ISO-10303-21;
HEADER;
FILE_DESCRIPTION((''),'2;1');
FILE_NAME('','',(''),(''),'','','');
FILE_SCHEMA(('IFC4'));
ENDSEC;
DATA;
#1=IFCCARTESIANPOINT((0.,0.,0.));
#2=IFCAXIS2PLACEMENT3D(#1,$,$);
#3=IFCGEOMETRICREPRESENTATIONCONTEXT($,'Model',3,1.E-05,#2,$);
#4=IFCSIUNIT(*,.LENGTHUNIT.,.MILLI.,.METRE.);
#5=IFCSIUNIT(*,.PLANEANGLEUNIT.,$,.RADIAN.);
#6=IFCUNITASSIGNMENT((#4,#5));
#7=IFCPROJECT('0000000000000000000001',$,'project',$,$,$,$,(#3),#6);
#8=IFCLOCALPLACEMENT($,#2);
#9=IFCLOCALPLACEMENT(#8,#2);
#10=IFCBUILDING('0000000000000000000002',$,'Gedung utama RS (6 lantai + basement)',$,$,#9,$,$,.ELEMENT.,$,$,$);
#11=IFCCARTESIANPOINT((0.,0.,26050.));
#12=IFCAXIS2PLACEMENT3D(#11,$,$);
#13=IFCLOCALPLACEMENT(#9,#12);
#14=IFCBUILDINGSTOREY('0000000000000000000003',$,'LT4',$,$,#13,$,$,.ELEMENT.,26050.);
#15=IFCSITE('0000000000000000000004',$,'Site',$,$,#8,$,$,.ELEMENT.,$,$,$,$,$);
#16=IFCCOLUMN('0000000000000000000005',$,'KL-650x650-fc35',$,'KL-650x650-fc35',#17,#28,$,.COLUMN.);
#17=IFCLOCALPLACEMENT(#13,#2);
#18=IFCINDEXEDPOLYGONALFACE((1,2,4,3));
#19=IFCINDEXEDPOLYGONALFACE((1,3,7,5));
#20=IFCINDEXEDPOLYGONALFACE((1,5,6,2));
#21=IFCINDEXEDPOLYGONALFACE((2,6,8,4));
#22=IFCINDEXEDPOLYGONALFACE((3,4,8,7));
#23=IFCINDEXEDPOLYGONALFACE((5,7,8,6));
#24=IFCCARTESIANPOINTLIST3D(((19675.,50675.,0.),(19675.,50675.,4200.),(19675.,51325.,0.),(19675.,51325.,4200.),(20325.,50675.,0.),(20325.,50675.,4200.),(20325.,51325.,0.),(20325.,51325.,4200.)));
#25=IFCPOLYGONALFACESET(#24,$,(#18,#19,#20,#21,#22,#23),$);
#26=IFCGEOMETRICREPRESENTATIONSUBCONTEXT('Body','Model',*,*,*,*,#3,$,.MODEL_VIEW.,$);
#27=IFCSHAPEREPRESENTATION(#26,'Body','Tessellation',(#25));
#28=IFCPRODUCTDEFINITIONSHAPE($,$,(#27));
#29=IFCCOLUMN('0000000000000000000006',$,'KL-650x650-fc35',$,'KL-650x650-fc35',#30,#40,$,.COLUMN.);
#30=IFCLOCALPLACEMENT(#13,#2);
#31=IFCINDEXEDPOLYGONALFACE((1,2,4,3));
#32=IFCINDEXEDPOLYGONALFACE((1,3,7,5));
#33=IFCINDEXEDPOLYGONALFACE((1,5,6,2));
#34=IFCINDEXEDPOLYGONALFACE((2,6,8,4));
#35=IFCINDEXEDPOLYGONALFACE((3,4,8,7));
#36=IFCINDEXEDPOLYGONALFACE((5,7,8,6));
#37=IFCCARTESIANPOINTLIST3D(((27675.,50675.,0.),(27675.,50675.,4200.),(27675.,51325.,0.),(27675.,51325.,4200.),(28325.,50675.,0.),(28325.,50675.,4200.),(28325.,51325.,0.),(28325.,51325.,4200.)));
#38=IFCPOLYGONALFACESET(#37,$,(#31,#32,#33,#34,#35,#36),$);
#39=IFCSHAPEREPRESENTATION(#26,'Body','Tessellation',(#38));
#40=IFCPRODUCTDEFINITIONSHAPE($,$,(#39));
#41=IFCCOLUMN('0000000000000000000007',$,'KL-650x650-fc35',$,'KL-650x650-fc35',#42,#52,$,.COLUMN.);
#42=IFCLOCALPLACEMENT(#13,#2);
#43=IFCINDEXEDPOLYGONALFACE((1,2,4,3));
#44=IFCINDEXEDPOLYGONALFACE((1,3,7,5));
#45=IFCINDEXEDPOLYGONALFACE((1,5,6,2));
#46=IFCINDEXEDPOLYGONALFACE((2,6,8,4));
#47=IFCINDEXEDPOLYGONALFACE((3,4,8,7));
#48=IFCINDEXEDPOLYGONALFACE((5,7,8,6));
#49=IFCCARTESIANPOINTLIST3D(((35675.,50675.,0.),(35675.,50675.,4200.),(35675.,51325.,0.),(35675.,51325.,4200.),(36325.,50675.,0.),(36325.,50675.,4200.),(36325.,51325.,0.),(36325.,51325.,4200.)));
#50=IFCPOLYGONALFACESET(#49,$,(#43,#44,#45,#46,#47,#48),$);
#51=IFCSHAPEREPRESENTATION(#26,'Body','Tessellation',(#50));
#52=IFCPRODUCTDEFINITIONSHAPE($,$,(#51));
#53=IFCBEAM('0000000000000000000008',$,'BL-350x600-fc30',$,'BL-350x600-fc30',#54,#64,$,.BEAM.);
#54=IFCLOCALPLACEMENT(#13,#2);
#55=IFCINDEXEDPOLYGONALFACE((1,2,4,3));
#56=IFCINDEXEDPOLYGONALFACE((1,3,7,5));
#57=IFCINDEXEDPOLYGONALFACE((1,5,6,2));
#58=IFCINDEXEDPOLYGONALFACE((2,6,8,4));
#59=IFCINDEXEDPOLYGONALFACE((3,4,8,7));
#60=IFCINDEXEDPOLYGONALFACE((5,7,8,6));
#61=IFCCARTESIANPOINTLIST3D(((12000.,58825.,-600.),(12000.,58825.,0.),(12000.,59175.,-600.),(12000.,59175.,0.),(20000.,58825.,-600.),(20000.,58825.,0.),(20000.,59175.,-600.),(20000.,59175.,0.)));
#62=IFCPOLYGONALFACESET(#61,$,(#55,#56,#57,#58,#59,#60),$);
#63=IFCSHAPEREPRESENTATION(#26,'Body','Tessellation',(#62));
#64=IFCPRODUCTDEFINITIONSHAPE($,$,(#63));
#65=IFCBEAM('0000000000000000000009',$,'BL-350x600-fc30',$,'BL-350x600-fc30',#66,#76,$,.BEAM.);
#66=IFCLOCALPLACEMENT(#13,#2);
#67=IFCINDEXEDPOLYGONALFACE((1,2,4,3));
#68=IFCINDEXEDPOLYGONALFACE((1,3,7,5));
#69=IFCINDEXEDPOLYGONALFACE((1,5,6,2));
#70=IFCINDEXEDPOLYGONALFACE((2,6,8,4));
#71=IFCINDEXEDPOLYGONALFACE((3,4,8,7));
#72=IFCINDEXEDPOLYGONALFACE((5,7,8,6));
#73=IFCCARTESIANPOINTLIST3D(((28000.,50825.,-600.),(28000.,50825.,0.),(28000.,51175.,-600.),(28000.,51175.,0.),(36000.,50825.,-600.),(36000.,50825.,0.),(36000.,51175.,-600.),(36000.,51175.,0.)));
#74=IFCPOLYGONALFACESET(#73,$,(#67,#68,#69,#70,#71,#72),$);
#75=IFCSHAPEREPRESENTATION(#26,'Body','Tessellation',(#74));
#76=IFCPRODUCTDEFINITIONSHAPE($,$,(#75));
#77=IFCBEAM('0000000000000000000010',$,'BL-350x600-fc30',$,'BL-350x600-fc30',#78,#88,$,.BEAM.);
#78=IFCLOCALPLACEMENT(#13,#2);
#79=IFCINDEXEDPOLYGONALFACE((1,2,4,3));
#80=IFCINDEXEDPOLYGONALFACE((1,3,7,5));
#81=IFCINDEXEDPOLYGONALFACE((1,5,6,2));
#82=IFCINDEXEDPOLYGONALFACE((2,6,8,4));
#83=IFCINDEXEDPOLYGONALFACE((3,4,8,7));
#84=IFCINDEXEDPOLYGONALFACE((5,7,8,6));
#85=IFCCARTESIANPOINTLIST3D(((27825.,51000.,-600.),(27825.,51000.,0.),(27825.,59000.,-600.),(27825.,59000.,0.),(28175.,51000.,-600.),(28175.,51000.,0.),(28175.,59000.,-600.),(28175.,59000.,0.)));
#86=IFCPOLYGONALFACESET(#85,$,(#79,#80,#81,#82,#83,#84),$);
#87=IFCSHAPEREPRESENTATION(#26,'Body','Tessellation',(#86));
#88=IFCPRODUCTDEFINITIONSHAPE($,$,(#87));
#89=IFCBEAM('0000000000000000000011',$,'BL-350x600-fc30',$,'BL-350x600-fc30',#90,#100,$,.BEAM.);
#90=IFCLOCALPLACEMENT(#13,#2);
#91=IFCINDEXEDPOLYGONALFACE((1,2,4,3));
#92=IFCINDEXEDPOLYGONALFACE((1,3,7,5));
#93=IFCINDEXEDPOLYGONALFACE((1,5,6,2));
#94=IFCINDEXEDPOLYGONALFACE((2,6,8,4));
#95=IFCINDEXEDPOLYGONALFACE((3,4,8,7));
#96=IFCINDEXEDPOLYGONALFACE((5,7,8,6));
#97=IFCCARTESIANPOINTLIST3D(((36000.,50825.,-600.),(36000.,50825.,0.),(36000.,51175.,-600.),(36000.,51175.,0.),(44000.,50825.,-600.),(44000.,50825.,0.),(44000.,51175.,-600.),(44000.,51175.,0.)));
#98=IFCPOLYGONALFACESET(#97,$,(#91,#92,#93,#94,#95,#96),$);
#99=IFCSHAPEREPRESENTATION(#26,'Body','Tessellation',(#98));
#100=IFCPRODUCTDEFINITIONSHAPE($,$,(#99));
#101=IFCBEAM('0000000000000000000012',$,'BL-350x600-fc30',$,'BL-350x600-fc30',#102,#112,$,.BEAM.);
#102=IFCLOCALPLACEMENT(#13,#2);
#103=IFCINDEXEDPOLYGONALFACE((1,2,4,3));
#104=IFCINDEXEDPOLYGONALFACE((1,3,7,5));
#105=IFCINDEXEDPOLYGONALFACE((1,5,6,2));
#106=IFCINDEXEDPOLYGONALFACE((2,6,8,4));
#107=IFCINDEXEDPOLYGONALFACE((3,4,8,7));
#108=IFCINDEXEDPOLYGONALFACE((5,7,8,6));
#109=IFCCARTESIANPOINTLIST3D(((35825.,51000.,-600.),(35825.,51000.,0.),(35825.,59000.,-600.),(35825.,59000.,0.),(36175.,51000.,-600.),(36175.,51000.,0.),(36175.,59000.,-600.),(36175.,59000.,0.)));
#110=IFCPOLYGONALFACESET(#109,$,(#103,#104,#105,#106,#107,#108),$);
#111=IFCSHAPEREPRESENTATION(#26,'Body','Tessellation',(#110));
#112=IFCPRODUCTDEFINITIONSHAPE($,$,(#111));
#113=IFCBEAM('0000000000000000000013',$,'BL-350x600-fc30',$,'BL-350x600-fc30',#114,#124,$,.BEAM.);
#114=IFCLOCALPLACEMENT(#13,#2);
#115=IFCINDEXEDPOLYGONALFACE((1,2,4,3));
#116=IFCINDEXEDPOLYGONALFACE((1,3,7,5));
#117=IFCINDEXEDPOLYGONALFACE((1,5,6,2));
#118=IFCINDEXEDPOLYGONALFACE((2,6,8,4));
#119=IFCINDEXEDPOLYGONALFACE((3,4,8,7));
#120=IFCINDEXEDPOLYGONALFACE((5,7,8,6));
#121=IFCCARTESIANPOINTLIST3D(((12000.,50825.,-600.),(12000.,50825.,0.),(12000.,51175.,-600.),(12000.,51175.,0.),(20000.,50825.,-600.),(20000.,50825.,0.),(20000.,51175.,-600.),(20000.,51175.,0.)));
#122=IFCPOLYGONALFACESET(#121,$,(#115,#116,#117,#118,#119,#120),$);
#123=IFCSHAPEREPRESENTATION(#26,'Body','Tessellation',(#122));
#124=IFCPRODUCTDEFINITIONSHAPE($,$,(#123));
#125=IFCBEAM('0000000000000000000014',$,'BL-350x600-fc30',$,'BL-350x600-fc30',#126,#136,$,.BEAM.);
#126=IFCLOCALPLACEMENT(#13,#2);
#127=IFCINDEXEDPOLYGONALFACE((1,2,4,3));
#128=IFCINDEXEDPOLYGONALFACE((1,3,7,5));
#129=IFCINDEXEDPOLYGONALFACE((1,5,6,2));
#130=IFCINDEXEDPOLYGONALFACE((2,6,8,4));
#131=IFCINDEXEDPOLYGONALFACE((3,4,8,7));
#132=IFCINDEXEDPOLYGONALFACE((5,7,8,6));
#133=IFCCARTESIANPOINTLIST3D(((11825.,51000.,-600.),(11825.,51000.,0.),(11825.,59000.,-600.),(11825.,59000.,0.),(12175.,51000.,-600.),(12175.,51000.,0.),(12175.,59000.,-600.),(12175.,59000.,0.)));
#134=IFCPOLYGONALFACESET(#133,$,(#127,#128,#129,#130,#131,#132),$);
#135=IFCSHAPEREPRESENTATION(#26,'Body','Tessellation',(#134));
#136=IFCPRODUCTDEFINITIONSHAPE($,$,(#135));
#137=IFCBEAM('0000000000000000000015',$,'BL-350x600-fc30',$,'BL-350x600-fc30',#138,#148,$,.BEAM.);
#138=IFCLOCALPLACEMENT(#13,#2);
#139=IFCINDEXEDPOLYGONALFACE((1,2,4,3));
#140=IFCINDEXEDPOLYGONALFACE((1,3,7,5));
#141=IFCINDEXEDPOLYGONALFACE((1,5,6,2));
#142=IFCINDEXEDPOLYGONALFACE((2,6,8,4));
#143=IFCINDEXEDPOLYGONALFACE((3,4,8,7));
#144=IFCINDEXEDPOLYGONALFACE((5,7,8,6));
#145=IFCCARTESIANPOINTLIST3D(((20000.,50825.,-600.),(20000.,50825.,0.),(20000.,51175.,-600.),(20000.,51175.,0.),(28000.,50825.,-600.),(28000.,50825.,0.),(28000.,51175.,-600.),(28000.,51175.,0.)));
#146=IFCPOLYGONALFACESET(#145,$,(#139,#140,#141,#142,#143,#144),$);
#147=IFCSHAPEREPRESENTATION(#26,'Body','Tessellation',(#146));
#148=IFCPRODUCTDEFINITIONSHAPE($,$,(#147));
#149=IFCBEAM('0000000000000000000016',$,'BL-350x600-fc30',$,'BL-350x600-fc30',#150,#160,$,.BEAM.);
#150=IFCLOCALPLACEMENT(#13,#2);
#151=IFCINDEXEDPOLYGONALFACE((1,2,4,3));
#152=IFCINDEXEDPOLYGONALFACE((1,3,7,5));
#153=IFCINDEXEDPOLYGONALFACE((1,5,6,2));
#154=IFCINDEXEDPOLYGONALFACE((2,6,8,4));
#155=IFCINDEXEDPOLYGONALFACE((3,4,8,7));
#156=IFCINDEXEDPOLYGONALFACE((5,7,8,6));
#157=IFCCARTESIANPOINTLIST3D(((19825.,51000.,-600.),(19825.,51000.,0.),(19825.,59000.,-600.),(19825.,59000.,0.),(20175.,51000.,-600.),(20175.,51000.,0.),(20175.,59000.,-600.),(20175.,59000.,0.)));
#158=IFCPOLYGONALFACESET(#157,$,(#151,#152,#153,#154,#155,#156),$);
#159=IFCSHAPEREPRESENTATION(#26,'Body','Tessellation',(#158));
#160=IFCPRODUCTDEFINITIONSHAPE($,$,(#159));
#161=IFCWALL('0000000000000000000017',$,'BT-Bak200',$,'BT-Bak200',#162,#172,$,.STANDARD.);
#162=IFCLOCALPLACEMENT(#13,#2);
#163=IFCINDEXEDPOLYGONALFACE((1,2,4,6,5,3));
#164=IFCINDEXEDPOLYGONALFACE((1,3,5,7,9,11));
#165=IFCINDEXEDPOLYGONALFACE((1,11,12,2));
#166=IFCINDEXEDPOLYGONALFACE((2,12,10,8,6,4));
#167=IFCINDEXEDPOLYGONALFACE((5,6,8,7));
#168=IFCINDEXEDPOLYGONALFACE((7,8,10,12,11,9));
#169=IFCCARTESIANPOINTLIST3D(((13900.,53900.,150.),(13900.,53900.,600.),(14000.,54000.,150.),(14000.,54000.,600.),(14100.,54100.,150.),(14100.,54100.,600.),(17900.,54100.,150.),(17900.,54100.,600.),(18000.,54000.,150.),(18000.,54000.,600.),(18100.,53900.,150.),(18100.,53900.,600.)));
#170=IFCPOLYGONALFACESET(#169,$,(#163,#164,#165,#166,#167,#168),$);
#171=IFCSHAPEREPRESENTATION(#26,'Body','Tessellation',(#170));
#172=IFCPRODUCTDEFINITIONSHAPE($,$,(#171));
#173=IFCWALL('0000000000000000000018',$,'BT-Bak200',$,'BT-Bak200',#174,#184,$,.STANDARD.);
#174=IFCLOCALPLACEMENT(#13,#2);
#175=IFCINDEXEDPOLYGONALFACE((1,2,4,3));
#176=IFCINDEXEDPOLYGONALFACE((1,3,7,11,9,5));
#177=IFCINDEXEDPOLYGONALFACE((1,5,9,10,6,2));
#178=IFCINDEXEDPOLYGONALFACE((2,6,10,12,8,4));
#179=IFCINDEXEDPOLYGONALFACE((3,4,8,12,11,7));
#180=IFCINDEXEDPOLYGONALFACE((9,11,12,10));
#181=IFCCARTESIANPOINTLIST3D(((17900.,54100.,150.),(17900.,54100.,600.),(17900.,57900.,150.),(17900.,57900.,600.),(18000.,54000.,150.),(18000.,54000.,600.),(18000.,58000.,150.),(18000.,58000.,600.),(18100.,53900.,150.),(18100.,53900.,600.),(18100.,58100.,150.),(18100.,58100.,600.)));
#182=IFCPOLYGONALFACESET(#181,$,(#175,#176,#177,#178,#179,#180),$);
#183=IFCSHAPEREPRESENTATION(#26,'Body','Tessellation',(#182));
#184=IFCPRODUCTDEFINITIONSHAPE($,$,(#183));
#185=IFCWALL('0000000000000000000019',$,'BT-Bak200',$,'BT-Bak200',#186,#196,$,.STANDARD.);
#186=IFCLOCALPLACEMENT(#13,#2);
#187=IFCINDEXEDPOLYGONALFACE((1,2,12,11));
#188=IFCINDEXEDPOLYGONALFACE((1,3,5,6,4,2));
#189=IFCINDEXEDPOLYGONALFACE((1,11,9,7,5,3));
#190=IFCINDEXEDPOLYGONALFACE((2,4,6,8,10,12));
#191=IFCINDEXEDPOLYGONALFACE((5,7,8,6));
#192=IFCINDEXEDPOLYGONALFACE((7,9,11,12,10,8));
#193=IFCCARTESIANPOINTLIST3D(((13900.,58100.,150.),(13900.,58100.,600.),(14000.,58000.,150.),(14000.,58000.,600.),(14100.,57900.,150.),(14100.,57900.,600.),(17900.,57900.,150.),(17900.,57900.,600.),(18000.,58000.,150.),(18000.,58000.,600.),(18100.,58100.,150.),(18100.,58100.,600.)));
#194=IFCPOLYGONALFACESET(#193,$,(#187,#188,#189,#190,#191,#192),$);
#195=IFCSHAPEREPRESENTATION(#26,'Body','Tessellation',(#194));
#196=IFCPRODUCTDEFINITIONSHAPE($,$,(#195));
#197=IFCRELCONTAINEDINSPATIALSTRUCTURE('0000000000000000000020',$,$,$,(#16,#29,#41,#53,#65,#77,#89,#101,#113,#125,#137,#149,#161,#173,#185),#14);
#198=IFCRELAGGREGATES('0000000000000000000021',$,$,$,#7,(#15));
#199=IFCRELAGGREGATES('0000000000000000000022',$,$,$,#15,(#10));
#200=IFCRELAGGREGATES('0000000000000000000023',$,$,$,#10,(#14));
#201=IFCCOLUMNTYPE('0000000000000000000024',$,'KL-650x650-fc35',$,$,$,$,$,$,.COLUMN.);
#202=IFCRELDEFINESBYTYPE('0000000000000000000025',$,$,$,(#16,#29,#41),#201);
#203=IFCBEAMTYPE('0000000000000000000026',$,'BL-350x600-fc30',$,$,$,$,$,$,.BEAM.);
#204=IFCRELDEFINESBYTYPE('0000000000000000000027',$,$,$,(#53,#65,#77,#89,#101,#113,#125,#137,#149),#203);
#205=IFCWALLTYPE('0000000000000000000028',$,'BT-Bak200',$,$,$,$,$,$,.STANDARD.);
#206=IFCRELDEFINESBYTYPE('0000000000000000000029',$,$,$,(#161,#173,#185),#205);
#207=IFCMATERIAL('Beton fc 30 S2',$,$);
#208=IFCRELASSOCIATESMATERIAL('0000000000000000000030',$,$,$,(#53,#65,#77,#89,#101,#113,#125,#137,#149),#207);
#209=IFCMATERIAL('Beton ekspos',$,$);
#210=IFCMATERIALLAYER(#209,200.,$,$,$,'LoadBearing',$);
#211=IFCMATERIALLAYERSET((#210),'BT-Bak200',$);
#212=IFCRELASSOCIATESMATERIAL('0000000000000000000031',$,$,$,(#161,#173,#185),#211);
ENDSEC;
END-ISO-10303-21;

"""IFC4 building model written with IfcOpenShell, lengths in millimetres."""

from ifc_helpers import new_model, si_unit, frame, origin, origin_2d, place, context, subcontext, project, spatial, polyline, rectangle, outline, extrude, material, layer, layer_set, layer_usage, material_profile, profile_set, profile_usage, type_object, element, save


model = new_model("IFC4")

# Units and contexts
model_context = context("Model", 3, precision=1e-05, world=origin())
body_context = subcontext(model_context, "Body", "Model", "MODEL_VIEW")
ifc_project = project(units=[si_unit("LENGTHUNIT", "METRE", prefix="MILLI"), si_unit("PLANEANGLEUNIT", "RADIAN")], contexts=[model_context])

# Site, building, storey
site_placement = place(None, origin())
site = spatial("IfcSite", under=ifc_project, at=site_placement, Name="Site", CompositionType="ELEMENT")
building_placement = place(site_placement, origin())
building = spatial("IfcBuilding", under=site, at=building_placement, Name="Gedung utama RS (6 lantai + basement)", CompositionType="ELEMENT")
storey_placement = place(building_placement, frame((0.0, 0.0, 26050.0)))
storey = spatial("IfcBuildingStorey", under=building, at=storey_placement, Name="LT4", CompositionType="ELEMENT", Elevation=26050.0)

# Columns
ifc_material_profile_1 = material_profile(None, rectangle(XDim=650.0, YDim=650.0, at=origin_2d()), Name="KL-650x650-fc35")
ifc_profile_set_1 = profile_set([ifc_material_profile_1], Name="KL-650x650-fc35")
ifc_profile_usage_1 = profile_usage(ifc_profile_set_1, cardinal=5)
column_type = type_object("IfcColumnType", Name="KL-650x650-fc35", PredefinedType="COLUMN")
for number, where, z_axis, x_axis, name in (
    (1, (20000.0, 51000.0, 0.0), (0.0, 0.0, 1.0), (1.0, 0.0, 0.0), "KL-650x650-fc35"),
    (2, (28000.0, 51000.0, 0.0), (0.0, 0.0, 1.0), (1.0, 0.0, 0.0), "KL-650x650-fc35"),
    (3, (36000.0, 51000.0, 0.0), (0.0, 0.0, 1.0), (1.0, 0.0, 0.0), "KL-650x650-fc35"),
):
    element("IfcColumn", number, at=place(storey_placement, frame(where, z_axis=z_axis, x_axis=x_axis)), inside=storey, type_object=column_type, material=ifc_profile_usage_1, Name=name, ObjectType="KL-650x650-fc35", PredefinedType="COLUMN", context=body_context, shape_type="SweptSolid", body=[
        extrude(rectangle(XDim=650.0, YDim=650.0, at=origin_2d()), origin(), (0.0, 0.0, 1.0), 4200.0),
    ])

# Beams
ifc_material_1 = material(Name="Beton fc 30 S2")
ifc_material_profile_2 = material_profile(ifc_material_1, rectangle(XDim=350.0, YDim=600.0, at=origin_2d()), Name="BL-350x600-fc30")
ifc_profile_set_2 = profile_set([ifc_material_profile_2], Name="BL-350x600-fc30")
ifc_profile_usage_2 = profile_usage(ifc_profile_set_2, cardinal=8)
beam_type = type_object("IfcBeamType", Name="BL-350x600-fc30", PredefinedType="BEAM")
for number, where, name in (
    (4, (12000.0, 59000.0, -300.0), "BL-350x600-fc30"),
    (5, (28000.0, 51000.0, -300.0), "BL-350x600-fc30"),
):
    element("IfcBeam", number, at=place(storey_placement, frame(where)), inside=storey, type_object=beam_type, material=ifc_profile_usage_2, Name=name, ObjectType="BL-350x600-fc30", PredefinedType="BEAM", context=body_context, shape_type="SweptSolid", body=[
        extrude(rectangle(XDim=350.0, YDim=600.0, at=origin_2d()), frame((0.0, 0.0, 0.0), z_axis=(1.0, 0.0, 0.0), x_axis=(0.0, 1.0, 0.0)), (0.0, 0.0, 1.0), 8000.0),
    ])
beam_1_placement = place(storey_placement, frame((28000.0, 51000.0, -300.0)))
element("IfcBeam", 6, at=beam_1_placement, inside=storey, type_object=beam_type, material=ifc_profile_usage_2, Name="BL-350x600-fc30", ObjectType="BL-350x600-fc30", PredefinedType="BEAM", context=body_context, shape_type="SweptSolid", body=[
    extrude(rectangle(XDim=350.0, YDim=600.0, at=origin_2d()), frame((0.0, 0.0, 0.0), z_axis=(0.0, 1.0, 0.0), x_axis=(-1.0, 0.0, 0.0)), (0.0, 0.0, 1.0), 8000.0),
])
beam_2_placement = place(storey_placement, frame((36000.0, 51000.0, -300.0)))
element("IfcBeam", 7, at=beam_2_placement, inside=storey, type_object=beam_type, material=ifc_profile_usage_2, Name="BL-350x600-fc30", ObjectType="BL-350x600-fc30", PredefinedType="BEAM", context=body_context, shape_type="SweptSolid", body=[
    extrude(rectangle(XDim=350.0, YDim=600.0, at=origin_2d()), frame((0.0, 0.0, 0.0), z_axis=(1.0, 0.0, 0.0), x_axis=(0.0, 1.0, 0.0)), (0.0, 0.0, 1.0), 8000.0),
])
beam_3_placement = place(storey_placement, frame((36000.0, 51000.0, -300.0)))
element("IfcBeam", 8, at=beam_3_placement, inside=storey, type_object=beam_type, material=ifc_profile_usage_2, Name="BL-350x600-fc30", ObjectType="BL-350x600-fc30", PredefinedType="BEAM", context=body_context, shape_type="SweptSolid", body=[
    extrude(rectangle(XDim=350.0, YDim=600.0, at=origin_2d()), frame((0.0, 0.0, 0.0), z_axis=(0.0, 1.0, 0.0), x_axis=(-1.0, 0.0, 0.0)), (0.0, 0.0, 1.0), 8000.0),
])
beam_4_placement = place(storey_placement, frame((12000.0, 51000.0, -300.0)))
element("IfcBeam", 9, at=beam_4_placement, inside=storey, type_object=beam_type, material=ifc_profile_usage_2, Name="BL-350x600-fc30", ObjectType="BL-350x600-fc30", PredefinedType="BEAM", context=body_context, shape_type="SweptSolid", body=[
    extrude(rectangle(XDim=350.0, YDim=600.0, at=origin_2d()), frame((0.0, 0.0, 0.0), z_axis=(1.0, 0.0, 0.0), x_axis=(0.0, 1.0, 0.0)), (0.0, 0.0, 1.0), 8000.0),
])
beam_5_placement = place(storey_placement, frame((12000.0, 51000.0, -300.0)))
element("IfcBeam", 10, at=beam_5_placement, inside=storey, type_object=beam_type, material=ifc_profile_usage_2, Name="BL-350x600-fc30", ObjectType="BL-350x600-fc30", PredefinedType="BEAM", context=body_context, shape_type="SweptSolid", body=[
    extrude(rectangle(XDim=350.0, YDim=600.0, at=origin_2d()), frame((0.0, 0.0, 0.0), z_axis=(0.0, 1.0, 0.0), x_axis=(-1.0, 0.0, 0.0)), (0.0, 0.0, 1.0), 8000.0),
])
beam_6_placement = place(storey_placement, frame((20000.0, 51000.0, -300.0)))
element("IfcBeam", 11, at=beam_6_placement, inside=storey, type_object=beam_type, material=ifc_profile_usage_2, Name="BL-350x600-fc30", ObjectType="BL-350x600-fc30", PredefinedType="BEAM", context=body_context, shape_type="SweptSolid", body=[
    extrude(rectangle(XDim=350.0, YDim=600.0, at=origin_2d()), frame((0.0, 0.0, 0.0), z_axis=(1.0, 0.0, 0.0), x_axis=(0.0, 1.0, 0.0)), (0.0, 0.0, 1.0), 8000.0),
])
beam_7_placement = place(storey_placement, frame((20000.0, 51000.0, -300.0)))
element("IfcBeam", 12, at=beam_7_placement, inside=storey, type_object=beam_type, material=ifc_profile_usage_2, Name="BL-350x600-fc30", ObjectType="BL-350x600-fc30", PredefinedType="BEAM", context=body_context, shape_type="SweptSolid", body=[
    extrude(rectangle(XDim=350.0, YDim=600.0, at=origin_2d()), frame((0.0, 0.0, 0.0), z_axis=(0.0, 1.0, 0.0), x_axis=(-1.0, 0.0, 0.0)), (0.0, 0.0, 1.0), 8000.0),
])

# Walls
ifc_material_2 = material(Name="Beton ekspos")
ifc_layer_1 = layer(ifc_material_2, 200.0, Category="LoadBearing")
ifc_layer_set_1 = layer_set([ifc_layer_1], Name="BT-Bak200")
ifc_layer_usage_1 = layer_usage(ifc_layer_set_1, "AXIS2", "NEGATIVE", 100.0)
wall_type_1 = type_object("IfcWallType", Name="BT-Bak200", PredefinedType="STANDARD")
for number, where, z_axis, x_axis, name in (
    (13, (14000.0, 54000.0, 150.0), (0.0, 0.0, 1.0), (1.0, 0.0, 0.0), "BT-Bak200"),
    (14, (18000.0, 54000.0, 150.0), (0.0, 0.0, 1.0), (0.0, 1.0, 0.0), "BT-Bak200"),
    (15, (18000.0, 58000.0, 150.0), (0.0, 0.0, 1.0), (-1.0, 0.0, 0.0), "BT-Bak200"),
):
    element("IfcWall", number, at=place(storey_placement, frame(where, z_axis=z_axis, x_axis=x_axis)), inside=storey, type_object=wall_type_1, material=ifc_layer_usage_1, Name=name, ObjectType="BT-Bak200", PredefinedType="STANDARD", context=body_context, shape_type="SweptSolid", body=[
        extrude(outline(polyline([(-100.0, -100.0), (0.0, 0.0), (100.0, 100.0), (3900.0, 100.0), (4000.0, 0.0), (4100.0, -100.0), (-100.0, -100.0)])), origin(), (0.0, 0.0, 1.0), 450.0),
    ])

save(model, "model.ifc")
